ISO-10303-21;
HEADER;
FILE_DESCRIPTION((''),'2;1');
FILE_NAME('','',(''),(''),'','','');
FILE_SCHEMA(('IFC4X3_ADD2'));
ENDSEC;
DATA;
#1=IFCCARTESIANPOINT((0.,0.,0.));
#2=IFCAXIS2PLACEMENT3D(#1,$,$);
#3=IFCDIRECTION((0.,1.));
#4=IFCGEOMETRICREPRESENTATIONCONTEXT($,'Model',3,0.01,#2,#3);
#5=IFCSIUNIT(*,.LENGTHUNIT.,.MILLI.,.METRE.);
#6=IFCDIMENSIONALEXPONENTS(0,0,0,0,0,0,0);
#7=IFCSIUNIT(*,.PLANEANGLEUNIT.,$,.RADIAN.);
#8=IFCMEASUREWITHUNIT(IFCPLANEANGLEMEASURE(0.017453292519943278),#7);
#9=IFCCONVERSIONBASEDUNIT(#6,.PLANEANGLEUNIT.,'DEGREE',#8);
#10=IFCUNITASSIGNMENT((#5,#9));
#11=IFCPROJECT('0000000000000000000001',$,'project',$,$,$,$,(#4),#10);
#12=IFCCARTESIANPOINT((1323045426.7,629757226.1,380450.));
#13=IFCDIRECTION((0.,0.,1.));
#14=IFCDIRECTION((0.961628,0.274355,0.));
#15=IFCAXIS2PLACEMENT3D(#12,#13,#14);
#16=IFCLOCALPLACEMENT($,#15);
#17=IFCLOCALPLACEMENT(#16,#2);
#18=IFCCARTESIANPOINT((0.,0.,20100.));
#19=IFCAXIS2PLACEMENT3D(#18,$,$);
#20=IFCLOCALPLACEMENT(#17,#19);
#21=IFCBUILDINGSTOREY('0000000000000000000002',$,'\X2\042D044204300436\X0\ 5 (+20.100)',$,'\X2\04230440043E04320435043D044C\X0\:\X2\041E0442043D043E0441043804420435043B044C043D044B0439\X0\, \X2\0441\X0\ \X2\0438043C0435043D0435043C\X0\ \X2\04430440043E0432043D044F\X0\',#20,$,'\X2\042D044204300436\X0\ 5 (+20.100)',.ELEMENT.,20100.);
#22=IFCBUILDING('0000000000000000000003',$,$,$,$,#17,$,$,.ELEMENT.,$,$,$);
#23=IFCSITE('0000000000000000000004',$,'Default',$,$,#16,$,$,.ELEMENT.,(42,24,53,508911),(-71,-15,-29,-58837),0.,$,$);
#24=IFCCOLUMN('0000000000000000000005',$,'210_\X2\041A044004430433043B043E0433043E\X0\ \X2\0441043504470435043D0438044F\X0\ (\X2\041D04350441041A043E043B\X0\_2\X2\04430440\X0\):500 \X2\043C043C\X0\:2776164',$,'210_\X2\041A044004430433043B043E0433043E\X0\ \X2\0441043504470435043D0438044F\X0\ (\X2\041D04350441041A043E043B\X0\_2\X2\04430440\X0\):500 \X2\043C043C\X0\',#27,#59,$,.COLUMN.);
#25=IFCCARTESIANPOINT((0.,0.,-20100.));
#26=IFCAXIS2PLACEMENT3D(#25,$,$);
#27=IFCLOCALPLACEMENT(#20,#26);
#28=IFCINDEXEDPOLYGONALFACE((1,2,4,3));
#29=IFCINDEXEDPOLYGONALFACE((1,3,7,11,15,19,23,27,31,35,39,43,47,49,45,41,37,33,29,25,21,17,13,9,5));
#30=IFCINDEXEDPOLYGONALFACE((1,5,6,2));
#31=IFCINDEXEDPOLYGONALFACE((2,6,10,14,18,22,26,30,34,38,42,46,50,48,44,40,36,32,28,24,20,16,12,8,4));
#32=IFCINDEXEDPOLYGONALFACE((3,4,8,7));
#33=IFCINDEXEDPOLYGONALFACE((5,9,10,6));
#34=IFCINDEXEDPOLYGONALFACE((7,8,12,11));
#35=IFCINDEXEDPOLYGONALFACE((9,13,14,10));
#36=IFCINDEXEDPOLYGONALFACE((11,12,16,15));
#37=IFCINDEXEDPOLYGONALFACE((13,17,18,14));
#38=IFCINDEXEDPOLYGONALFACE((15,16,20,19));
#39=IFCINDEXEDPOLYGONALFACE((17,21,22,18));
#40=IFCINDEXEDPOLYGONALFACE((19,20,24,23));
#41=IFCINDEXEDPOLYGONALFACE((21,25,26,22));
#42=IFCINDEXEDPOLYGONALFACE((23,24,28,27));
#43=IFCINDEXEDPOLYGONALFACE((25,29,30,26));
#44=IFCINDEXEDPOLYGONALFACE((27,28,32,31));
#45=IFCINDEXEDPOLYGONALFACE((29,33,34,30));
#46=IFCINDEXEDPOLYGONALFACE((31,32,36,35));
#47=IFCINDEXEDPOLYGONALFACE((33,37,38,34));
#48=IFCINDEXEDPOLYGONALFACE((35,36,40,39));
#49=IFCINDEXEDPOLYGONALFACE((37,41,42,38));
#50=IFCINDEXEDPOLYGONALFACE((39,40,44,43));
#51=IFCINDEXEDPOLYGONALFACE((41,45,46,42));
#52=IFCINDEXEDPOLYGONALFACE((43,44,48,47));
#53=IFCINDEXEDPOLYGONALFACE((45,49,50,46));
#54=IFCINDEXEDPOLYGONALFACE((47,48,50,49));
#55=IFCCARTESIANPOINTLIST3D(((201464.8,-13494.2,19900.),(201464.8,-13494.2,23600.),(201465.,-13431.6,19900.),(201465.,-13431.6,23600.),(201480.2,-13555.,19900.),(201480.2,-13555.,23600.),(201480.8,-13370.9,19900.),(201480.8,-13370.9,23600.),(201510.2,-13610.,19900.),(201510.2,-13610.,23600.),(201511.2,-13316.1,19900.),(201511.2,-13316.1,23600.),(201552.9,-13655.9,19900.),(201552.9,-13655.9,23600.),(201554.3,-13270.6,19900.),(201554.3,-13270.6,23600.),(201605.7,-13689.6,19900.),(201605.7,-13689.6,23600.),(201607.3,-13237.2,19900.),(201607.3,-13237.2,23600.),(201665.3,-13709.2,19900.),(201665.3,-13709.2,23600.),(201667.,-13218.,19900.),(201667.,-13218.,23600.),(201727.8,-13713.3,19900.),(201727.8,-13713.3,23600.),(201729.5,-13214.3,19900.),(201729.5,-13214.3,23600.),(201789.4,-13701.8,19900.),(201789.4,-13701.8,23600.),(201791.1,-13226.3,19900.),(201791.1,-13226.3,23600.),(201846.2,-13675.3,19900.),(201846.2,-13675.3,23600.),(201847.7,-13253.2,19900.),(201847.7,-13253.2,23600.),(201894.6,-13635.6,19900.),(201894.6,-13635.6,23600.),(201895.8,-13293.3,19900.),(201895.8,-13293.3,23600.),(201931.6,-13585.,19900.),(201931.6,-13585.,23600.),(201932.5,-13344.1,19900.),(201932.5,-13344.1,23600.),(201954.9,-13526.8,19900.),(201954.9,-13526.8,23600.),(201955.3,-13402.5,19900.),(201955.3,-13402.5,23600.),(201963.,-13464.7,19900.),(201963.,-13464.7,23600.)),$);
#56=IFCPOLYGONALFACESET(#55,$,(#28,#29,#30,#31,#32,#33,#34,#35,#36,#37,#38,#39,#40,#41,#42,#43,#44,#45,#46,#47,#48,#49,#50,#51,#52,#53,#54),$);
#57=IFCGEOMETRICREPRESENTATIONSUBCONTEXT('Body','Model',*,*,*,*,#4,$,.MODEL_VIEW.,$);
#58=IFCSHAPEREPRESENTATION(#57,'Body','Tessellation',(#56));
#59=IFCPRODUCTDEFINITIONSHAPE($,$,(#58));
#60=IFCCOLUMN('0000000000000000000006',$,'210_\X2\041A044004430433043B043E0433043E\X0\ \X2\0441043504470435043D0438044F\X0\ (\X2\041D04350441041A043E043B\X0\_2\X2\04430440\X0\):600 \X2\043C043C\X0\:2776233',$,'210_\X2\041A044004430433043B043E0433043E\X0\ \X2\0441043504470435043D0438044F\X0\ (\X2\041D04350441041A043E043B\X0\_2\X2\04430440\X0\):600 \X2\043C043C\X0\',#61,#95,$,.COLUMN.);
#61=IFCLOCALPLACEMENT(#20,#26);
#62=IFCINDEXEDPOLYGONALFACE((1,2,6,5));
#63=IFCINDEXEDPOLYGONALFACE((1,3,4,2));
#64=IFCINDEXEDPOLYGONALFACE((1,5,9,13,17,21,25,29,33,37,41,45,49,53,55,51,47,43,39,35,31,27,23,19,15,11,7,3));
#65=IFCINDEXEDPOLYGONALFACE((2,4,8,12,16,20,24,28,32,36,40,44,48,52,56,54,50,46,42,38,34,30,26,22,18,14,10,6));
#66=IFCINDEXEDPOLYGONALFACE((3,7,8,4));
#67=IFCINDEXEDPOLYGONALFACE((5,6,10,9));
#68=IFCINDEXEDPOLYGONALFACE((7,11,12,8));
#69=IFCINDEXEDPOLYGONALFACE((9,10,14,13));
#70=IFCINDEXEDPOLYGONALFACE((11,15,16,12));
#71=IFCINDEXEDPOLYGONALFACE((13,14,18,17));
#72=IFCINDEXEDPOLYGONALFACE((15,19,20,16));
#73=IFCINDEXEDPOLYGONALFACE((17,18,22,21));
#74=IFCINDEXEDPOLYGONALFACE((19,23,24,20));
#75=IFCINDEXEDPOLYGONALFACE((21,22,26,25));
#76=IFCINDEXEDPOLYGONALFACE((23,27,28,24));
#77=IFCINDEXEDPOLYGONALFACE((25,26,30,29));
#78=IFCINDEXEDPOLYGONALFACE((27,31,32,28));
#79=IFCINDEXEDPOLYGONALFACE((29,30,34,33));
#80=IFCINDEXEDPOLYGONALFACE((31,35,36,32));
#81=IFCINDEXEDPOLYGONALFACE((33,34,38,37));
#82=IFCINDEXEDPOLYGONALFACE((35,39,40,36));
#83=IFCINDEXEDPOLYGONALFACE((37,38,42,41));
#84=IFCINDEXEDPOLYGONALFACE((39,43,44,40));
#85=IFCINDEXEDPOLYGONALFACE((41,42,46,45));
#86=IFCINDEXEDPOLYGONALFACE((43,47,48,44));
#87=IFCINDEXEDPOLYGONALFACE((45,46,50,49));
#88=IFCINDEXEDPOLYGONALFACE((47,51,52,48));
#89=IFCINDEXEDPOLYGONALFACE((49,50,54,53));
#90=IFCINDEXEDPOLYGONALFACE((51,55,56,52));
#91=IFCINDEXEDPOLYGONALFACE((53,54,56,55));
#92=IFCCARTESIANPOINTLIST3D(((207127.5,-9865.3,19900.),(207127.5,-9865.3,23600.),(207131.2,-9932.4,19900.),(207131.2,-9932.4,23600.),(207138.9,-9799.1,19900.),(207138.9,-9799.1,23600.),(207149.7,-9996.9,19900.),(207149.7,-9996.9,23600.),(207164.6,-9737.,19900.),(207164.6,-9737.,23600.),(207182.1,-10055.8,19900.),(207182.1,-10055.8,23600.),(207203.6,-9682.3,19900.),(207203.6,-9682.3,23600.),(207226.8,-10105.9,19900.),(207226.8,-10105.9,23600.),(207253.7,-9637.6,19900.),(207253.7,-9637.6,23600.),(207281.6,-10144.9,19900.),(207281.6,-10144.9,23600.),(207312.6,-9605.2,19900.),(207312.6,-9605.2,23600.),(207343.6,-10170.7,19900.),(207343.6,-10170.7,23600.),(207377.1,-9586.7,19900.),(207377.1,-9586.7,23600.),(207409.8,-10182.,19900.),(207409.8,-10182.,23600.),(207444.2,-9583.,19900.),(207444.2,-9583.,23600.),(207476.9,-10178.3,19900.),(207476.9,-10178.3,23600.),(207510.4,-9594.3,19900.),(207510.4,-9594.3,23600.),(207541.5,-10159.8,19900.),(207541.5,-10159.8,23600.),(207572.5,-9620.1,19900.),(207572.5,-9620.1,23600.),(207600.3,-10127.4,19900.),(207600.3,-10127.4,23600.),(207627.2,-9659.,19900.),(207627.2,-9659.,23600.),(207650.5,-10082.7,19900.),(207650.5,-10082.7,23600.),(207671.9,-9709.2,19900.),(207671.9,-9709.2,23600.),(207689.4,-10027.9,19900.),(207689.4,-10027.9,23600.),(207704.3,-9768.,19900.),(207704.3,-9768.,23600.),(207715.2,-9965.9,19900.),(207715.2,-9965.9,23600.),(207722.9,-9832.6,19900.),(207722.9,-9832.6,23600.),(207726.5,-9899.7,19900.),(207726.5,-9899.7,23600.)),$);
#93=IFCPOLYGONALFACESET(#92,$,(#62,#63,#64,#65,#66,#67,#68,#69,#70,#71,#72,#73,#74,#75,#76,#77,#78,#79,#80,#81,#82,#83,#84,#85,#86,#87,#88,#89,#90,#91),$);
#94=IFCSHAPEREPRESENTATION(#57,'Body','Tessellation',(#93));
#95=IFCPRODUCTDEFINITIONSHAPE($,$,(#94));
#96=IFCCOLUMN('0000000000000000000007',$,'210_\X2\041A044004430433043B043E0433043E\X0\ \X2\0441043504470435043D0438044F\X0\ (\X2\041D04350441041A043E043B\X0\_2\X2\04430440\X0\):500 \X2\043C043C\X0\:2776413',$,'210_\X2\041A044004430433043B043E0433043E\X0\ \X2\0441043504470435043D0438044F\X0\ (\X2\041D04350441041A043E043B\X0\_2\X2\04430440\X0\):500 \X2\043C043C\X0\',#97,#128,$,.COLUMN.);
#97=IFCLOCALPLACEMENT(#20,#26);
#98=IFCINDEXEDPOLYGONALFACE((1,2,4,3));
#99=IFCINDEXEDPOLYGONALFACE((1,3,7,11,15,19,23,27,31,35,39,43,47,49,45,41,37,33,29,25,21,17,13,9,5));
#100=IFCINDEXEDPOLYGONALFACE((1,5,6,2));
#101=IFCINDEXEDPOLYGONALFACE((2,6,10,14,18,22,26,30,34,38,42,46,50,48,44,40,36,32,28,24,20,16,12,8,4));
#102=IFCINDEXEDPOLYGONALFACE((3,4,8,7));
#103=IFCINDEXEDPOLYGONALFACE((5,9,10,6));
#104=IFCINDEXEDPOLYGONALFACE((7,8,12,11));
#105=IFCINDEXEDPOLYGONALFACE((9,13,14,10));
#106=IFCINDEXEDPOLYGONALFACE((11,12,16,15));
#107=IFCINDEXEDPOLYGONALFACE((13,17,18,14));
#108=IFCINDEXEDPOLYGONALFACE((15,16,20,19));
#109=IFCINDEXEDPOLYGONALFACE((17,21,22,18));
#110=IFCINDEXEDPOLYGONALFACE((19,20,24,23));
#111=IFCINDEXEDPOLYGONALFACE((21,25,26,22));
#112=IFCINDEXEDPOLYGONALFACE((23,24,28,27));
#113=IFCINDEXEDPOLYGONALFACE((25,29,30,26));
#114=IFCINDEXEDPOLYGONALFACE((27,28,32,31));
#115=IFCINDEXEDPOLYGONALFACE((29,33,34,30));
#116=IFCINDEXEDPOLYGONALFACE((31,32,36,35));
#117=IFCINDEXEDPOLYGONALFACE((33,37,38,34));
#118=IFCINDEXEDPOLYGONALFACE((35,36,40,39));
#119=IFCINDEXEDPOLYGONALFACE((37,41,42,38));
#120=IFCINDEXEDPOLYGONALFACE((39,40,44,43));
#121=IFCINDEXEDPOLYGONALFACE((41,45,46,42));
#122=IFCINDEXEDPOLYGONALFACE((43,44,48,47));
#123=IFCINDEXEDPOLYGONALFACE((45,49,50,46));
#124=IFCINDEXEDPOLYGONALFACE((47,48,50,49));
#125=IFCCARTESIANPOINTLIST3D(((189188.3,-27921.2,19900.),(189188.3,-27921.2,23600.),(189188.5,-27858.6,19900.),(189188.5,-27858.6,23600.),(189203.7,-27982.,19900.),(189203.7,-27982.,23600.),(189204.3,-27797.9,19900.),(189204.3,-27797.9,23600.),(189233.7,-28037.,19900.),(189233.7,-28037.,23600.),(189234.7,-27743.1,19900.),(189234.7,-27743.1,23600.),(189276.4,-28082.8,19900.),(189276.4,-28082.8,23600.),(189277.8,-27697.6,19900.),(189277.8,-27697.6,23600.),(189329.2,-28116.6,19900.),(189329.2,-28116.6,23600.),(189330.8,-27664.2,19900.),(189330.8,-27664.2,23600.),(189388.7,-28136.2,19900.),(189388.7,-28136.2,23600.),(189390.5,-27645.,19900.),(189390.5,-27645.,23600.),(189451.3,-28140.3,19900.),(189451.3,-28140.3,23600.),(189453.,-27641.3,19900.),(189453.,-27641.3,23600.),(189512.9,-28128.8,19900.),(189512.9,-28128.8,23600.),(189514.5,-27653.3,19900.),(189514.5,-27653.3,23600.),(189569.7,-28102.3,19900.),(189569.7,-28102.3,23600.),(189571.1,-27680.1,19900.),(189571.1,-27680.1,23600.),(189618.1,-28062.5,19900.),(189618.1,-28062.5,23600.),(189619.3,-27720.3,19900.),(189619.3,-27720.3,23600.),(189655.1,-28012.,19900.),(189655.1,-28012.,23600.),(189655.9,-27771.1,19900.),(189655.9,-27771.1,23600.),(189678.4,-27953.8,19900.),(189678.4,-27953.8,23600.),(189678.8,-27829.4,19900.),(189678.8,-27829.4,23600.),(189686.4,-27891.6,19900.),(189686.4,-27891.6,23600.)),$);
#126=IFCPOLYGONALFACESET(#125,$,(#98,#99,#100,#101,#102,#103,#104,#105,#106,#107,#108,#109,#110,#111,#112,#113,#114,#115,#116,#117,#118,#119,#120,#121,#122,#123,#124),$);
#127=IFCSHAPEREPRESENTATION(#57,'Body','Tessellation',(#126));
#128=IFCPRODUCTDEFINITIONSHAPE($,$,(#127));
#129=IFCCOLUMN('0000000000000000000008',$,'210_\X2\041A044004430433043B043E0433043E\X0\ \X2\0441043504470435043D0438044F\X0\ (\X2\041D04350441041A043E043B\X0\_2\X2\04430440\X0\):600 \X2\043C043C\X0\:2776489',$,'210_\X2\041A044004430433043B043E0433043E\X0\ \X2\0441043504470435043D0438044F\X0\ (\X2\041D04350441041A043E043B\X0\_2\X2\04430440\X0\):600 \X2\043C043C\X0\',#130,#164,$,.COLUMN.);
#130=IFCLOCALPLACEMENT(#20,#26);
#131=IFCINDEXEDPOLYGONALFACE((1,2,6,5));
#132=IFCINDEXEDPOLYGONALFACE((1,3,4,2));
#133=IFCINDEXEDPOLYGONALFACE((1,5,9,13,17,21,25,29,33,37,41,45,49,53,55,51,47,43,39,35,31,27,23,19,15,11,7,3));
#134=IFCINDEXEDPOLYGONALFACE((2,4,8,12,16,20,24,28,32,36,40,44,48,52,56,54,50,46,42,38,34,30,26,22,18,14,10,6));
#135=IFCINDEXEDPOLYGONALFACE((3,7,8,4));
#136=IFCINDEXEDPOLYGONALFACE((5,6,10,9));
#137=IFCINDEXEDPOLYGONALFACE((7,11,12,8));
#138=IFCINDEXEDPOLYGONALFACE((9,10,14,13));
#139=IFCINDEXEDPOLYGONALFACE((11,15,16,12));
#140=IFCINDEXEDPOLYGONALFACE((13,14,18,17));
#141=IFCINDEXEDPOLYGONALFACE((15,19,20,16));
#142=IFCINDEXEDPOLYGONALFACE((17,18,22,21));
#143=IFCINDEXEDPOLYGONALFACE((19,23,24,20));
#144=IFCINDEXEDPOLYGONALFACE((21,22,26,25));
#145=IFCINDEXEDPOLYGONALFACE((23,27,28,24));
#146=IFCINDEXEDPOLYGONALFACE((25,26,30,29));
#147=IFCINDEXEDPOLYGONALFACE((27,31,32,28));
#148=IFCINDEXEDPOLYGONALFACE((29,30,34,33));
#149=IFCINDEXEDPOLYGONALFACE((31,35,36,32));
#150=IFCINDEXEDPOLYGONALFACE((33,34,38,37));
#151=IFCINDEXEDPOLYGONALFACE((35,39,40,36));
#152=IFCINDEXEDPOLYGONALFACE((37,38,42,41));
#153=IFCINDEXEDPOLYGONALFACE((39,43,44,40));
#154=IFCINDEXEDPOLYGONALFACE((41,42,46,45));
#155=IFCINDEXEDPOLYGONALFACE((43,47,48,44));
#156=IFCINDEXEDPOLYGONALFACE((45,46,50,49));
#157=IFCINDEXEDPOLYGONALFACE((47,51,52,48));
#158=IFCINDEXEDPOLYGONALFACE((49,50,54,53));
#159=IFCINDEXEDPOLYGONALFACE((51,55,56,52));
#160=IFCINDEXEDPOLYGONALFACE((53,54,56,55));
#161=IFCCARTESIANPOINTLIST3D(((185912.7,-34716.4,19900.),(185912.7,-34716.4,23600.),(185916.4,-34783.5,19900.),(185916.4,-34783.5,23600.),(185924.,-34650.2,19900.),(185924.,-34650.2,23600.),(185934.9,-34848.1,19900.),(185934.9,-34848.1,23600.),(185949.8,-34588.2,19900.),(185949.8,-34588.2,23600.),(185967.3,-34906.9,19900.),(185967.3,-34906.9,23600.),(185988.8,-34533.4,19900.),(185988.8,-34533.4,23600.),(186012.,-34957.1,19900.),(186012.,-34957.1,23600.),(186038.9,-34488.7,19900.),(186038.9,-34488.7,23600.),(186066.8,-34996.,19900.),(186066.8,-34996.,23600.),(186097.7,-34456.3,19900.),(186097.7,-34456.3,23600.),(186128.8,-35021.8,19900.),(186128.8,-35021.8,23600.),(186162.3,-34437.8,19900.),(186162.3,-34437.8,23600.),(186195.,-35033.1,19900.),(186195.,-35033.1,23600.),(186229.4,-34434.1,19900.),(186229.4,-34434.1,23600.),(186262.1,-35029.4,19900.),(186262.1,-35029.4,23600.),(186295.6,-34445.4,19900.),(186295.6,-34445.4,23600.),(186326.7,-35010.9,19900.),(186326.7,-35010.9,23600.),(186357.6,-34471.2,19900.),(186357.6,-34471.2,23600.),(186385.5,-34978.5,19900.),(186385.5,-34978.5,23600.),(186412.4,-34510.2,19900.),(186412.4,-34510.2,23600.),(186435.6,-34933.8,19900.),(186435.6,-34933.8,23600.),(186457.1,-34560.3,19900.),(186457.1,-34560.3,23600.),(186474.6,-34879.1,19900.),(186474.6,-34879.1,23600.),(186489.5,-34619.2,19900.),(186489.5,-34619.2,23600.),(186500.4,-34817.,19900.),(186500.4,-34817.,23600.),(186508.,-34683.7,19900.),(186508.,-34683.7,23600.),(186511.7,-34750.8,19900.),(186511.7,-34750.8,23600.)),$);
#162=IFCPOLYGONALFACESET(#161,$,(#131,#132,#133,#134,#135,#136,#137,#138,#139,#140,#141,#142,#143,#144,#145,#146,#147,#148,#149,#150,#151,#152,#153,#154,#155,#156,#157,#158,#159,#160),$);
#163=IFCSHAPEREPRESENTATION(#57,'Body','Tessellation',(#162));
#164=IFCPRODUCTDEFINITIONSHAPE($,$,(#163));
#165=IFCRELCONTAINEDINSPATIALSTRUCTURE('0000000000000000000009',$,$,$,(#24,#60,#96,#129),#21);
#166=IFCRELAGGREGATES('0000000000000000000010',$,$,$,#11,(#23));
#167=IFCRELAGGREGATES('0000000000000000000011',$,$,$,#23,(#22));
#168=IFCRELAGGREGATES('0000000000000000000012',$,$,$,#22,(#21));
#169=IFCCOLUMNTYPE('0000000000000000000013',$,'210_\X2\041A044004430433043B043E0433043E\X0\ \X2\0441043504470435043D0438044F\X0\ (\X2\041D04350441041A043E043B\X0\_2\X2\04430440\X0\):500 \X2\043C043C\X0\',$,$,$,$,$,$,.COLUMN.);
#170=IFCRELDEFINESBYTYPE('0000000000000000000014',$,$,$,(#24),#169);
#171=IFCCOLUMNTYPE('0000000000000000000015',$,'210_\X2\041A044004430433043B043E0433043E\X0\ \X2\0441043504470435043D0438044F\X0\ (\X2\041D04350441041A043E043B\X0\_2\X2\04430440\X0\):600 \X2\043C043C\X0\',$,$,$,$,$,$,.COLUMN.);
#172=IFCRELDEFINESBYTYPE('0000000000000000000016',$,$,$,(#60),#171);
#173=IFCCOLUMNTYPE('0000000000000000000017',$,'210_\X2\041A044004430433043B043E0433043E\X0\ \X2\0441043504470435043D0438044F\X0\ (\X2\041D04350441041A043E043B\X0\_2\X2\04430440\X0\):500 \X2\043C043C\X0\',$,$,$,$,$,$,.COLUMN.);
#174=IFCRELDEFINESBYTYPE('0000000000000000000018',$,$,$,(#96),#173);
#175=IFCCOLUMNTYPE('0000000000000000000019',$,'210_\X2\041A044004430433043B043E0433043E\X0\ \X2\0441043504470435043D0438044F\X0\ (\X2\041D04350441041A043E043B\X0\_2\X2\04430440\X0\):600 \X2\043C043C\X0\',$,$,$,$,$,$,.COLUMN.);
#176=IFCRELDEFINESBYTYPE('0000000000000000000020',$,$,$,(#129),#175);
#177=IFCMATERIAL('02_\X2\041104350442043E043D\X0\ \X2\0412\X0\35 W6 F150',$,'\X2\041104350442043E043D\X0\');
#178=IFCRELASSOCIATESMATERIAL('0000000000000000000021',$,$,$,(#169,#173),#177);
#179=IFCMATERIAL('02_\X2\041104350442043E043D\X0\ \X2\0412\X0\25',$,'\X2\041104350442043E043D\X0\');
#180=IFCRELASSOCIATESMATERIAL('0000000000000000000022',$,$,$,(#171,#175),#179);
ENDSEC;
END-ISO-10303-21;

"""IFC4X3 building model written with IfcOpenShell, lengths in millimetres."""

from ifc_helpers import new_model, entity, si_unit, converted_unit, direction, frame, frame_2d, origin, place, context, subcontext, project, spatial, circle, extrude, source, transform, mapped, material, material_profile, profile_set, type_object, type_shapes, element, save


model = new_model("IFC4X3")

# Units and contexts
model_context = context("Model", 3, precision=0.01, world=origin(), true_north=direction((0.0, 1.0)))
body_context = subcontext(model_context, "Body", "Model", "MODEL_VIEW")
ifc_project = project(units=[si_unit("LENGTHUNIT", "METRE", prefix="MILLI"), converted_unit("PLANEANGLEUNIT", "DEGREE", entity("IfcPlaneAngleMeasure", 0.017453292519943278), si_unit("PLANEANGLEUNIT", "RADIAN"), dimensions=[0, 0, 0, 0, 0, 0, 0])], contexts=[model_context])

# Site, building, storey
site_placement = place(None, frame((1323045426.7, 629757226.1, 380450.0), z_axis=(0.0, 0.0, 1.0), x_axis=(0.961628, 0.274355, 0.0)))
site = spatial("IfcSite", under=ifc_project, at=site_placement, Name="Default", CompositionType="ELEMENT", RefLatitude=(42, 24, 53, 508911), RefLongitude=(-71, -15, -29, -58837), RefElevation=0.0)
building_placement = place(site_placement, origin())
building = spatial("IfcBuilding", under=site, at=building_placement, CompositionType="ELEMENT")
storey_placement = place(building_placement, frame((0.0, 0.0, 20100.0)))
storey = spatial("IfcBuildingStorey", under=building, at=storey_placement, Name="Этаж 5 (+20.100)", ObjectType="Уровень:Относительный, с именем уровня", LongName="Этаж 5 (+20.100)", CompositionType="ELEMENT", Elevation=20100.0)

# Columns
ifc_material_1 = material(Name="02_Бетон В35 W6 F150", Category="Бетон")
ifc_material_profile_1 = material_profile(ifc_material_1, circle(Radius=250.0, at=frame_2d((0.0, 0.0), x_axis=(1.0, 0.0))), Name="500 мм")
ifc_profile_set_1 = profile_set([ifc_material_profile_1], Name="500 мм")
ifc_material_2 = material(Name="02_Бетон В25", Category="Бетон")
ifc_material_profile_2 = material_profile(ifc_material_2, circle(Radius=300.0, at=frame_2d((0.0, 0.0), x_axis=(1.0, 0.0))), Name="600 мм")
ifc_profile_set_2 = profile_set([ifc_material_profile_2], Name="600 мм")
column_type_1 = type_object("IfcColumnType", Name="210_Круглого сечения (НесКол_2ур):500 мм", PredefinedType="COLUMN", material=ifc_profile_set_1)
shared_shape_1 = source(origin(), body_context, "Body", "SweptSolid", [
    extrude(circle(Radius=250.0, at=frame_2d((0.0, 0.0), x_axis=(1.0, 0.0))), frame((201713.0, -13463.8, 19900.0), z_axis=(0.0, 0.0, 1.0), x_axis=(0.87462, -0.48481, 0.0)), (0.0, 0.0, 1.0), 3700.0),
])
type_shapes(column_type_1, [shared_shape_1])
column_1_placement = place(storey_placement, frame((0.0, 0.0, -20100.0)))
element("IfcColumn", 1, at=column_1_placement, inside=storey, type_object=column_type_1, Name="210_Круглого сечения (НесКол_2ур):500 мм:2776164", ObjectType="210_Круглого сечения (НесКол_2ур):500 мм", PredefinedType="COLUMN", context=body_context, shape_type="MappedRepresentation", body=[
    mapped(shared_shape_1, transform((0.0, 0.0, 0.0), scale=1.0)),
])
column_type_2 = type_object("IfcColumnType", Name="210_Круглого сечения (НесКол_2ур):600 мм", PredefinedType="COLUMN", material=ifc_profile_set_2)
shared_shape_2 = source(origin(), body_context, "Body", "SweptSolid", [
    extrude(circle(Radius=300.0, at=frame_2d((0.0, 0.0), x_axis=(1.0, 0.0))), frame((207427.0, -9882.5, 19900.0), z_axis=(0.0, 0.0, 1.0), x_axis=(0.87462, -0.48481, 0.0)), (0.0, 0.0, 1.0), 3700.0),
])
type_shapes(column_type_2, [shared_shape_2])
column_2_placement = place(storey_placement, frame((0.0, 0.0, -20100.0)))
element("IfcColumn", 2, at=column_2_placement, inside=storey, type_object=column_type_2, Name="210_Круглого сечения (НесКол_2ур):600 мм:2776233", ObjectType="210_Круглого сечения (НесКол_2ур):600 мм", PredefinedType="COLUMN", context=body_context, shape_type="MappedRepresentation", body=[
    mapped(shared_shape_2, transform((0.0, 0.0, 0.0), scale=1.0)),
])
column_type_3 = type_object("IfcColumnType", Name="210_Круглого сечения (НесКол_2ур):500 мм", PredefinedType="COLUMN", material=ifc_profile_set_1)
shared_shape_3 = source(origin(), body_context, "Body", "SweptSolid", [
    extrude(circle(Radius=250.0, at=frame_2d((0.0, 0.0), x_axis=(1.0, 0.0))), frame((189436.4, -27890.7, 19900.0), z_axis=(0.0, 0.0, 1.0), x_axis=(0.87462, -0.48481, 0.0)), (0.0, 0.0, 1.0), 3700.0),
])
type_shapes(column_type_3, [shared_shape_3])
column_3_placement = place(storey_placement, frame((0.0, 0.0, -20100.0)))
element("IfcColumn", 3, at=column_3_placement, inside=storey, type_object=column_type_3, Name="210_Круглого сечения (НесКол_2ур):500 мм:2776413", ObjectType="210_Круглого сечения (НесКол_2ур):500 мм", PredefinedType="COLUMN", context=body_context, shape_type="MappedRepresentation", body=[
    mapped(shared_shape_3, transform((0.0, 0.0, 0.0), scale=1.0)),
])
column_type_4 = type_object("IfcColumnType", Name="210_Круглого сечения (НесКол_2ур):600 мм", PredefinedType="COLUMN", material=ifc_profile_set_2)
shared_shape_4 = source(origin(), body_context, "Body", "SweptSolid", [
    extrude(circle(Radius=300.0, at=frame_2d((0.0, 0.0), x_axis=(1.0, 0.0))), frame((186212.2, -34733.6, 19900.0), z_axis=(0.0, 0.0, 1.0), x_axis=(0.87462, -0.48481, 0.0)), (0.0, 0.0, 1.0), 3700.0),
])
type_shapes(column_type_4, [shared_shape_4])
column_4_placement = place(storey_placement, frame((0.0, 0.0, -20100.0)))
element("IfcColumn", 4, at=column_4_placement, inside=storey, type_object=column_type_4, Name="210_Круглого сечения (НесКол_2ур):600 мм:2776489", ObjectType="210_Круглого сечения (НесКол_2ур):600 мм", PredefinedType="COLUMN", context=body_context, shape_type="MappedRepresentation", body=[
    mapped(shared_shape_4, transform((0.0, 0.0, 0.0), scale=1.0)),
])

save(model, "model.ifc")
